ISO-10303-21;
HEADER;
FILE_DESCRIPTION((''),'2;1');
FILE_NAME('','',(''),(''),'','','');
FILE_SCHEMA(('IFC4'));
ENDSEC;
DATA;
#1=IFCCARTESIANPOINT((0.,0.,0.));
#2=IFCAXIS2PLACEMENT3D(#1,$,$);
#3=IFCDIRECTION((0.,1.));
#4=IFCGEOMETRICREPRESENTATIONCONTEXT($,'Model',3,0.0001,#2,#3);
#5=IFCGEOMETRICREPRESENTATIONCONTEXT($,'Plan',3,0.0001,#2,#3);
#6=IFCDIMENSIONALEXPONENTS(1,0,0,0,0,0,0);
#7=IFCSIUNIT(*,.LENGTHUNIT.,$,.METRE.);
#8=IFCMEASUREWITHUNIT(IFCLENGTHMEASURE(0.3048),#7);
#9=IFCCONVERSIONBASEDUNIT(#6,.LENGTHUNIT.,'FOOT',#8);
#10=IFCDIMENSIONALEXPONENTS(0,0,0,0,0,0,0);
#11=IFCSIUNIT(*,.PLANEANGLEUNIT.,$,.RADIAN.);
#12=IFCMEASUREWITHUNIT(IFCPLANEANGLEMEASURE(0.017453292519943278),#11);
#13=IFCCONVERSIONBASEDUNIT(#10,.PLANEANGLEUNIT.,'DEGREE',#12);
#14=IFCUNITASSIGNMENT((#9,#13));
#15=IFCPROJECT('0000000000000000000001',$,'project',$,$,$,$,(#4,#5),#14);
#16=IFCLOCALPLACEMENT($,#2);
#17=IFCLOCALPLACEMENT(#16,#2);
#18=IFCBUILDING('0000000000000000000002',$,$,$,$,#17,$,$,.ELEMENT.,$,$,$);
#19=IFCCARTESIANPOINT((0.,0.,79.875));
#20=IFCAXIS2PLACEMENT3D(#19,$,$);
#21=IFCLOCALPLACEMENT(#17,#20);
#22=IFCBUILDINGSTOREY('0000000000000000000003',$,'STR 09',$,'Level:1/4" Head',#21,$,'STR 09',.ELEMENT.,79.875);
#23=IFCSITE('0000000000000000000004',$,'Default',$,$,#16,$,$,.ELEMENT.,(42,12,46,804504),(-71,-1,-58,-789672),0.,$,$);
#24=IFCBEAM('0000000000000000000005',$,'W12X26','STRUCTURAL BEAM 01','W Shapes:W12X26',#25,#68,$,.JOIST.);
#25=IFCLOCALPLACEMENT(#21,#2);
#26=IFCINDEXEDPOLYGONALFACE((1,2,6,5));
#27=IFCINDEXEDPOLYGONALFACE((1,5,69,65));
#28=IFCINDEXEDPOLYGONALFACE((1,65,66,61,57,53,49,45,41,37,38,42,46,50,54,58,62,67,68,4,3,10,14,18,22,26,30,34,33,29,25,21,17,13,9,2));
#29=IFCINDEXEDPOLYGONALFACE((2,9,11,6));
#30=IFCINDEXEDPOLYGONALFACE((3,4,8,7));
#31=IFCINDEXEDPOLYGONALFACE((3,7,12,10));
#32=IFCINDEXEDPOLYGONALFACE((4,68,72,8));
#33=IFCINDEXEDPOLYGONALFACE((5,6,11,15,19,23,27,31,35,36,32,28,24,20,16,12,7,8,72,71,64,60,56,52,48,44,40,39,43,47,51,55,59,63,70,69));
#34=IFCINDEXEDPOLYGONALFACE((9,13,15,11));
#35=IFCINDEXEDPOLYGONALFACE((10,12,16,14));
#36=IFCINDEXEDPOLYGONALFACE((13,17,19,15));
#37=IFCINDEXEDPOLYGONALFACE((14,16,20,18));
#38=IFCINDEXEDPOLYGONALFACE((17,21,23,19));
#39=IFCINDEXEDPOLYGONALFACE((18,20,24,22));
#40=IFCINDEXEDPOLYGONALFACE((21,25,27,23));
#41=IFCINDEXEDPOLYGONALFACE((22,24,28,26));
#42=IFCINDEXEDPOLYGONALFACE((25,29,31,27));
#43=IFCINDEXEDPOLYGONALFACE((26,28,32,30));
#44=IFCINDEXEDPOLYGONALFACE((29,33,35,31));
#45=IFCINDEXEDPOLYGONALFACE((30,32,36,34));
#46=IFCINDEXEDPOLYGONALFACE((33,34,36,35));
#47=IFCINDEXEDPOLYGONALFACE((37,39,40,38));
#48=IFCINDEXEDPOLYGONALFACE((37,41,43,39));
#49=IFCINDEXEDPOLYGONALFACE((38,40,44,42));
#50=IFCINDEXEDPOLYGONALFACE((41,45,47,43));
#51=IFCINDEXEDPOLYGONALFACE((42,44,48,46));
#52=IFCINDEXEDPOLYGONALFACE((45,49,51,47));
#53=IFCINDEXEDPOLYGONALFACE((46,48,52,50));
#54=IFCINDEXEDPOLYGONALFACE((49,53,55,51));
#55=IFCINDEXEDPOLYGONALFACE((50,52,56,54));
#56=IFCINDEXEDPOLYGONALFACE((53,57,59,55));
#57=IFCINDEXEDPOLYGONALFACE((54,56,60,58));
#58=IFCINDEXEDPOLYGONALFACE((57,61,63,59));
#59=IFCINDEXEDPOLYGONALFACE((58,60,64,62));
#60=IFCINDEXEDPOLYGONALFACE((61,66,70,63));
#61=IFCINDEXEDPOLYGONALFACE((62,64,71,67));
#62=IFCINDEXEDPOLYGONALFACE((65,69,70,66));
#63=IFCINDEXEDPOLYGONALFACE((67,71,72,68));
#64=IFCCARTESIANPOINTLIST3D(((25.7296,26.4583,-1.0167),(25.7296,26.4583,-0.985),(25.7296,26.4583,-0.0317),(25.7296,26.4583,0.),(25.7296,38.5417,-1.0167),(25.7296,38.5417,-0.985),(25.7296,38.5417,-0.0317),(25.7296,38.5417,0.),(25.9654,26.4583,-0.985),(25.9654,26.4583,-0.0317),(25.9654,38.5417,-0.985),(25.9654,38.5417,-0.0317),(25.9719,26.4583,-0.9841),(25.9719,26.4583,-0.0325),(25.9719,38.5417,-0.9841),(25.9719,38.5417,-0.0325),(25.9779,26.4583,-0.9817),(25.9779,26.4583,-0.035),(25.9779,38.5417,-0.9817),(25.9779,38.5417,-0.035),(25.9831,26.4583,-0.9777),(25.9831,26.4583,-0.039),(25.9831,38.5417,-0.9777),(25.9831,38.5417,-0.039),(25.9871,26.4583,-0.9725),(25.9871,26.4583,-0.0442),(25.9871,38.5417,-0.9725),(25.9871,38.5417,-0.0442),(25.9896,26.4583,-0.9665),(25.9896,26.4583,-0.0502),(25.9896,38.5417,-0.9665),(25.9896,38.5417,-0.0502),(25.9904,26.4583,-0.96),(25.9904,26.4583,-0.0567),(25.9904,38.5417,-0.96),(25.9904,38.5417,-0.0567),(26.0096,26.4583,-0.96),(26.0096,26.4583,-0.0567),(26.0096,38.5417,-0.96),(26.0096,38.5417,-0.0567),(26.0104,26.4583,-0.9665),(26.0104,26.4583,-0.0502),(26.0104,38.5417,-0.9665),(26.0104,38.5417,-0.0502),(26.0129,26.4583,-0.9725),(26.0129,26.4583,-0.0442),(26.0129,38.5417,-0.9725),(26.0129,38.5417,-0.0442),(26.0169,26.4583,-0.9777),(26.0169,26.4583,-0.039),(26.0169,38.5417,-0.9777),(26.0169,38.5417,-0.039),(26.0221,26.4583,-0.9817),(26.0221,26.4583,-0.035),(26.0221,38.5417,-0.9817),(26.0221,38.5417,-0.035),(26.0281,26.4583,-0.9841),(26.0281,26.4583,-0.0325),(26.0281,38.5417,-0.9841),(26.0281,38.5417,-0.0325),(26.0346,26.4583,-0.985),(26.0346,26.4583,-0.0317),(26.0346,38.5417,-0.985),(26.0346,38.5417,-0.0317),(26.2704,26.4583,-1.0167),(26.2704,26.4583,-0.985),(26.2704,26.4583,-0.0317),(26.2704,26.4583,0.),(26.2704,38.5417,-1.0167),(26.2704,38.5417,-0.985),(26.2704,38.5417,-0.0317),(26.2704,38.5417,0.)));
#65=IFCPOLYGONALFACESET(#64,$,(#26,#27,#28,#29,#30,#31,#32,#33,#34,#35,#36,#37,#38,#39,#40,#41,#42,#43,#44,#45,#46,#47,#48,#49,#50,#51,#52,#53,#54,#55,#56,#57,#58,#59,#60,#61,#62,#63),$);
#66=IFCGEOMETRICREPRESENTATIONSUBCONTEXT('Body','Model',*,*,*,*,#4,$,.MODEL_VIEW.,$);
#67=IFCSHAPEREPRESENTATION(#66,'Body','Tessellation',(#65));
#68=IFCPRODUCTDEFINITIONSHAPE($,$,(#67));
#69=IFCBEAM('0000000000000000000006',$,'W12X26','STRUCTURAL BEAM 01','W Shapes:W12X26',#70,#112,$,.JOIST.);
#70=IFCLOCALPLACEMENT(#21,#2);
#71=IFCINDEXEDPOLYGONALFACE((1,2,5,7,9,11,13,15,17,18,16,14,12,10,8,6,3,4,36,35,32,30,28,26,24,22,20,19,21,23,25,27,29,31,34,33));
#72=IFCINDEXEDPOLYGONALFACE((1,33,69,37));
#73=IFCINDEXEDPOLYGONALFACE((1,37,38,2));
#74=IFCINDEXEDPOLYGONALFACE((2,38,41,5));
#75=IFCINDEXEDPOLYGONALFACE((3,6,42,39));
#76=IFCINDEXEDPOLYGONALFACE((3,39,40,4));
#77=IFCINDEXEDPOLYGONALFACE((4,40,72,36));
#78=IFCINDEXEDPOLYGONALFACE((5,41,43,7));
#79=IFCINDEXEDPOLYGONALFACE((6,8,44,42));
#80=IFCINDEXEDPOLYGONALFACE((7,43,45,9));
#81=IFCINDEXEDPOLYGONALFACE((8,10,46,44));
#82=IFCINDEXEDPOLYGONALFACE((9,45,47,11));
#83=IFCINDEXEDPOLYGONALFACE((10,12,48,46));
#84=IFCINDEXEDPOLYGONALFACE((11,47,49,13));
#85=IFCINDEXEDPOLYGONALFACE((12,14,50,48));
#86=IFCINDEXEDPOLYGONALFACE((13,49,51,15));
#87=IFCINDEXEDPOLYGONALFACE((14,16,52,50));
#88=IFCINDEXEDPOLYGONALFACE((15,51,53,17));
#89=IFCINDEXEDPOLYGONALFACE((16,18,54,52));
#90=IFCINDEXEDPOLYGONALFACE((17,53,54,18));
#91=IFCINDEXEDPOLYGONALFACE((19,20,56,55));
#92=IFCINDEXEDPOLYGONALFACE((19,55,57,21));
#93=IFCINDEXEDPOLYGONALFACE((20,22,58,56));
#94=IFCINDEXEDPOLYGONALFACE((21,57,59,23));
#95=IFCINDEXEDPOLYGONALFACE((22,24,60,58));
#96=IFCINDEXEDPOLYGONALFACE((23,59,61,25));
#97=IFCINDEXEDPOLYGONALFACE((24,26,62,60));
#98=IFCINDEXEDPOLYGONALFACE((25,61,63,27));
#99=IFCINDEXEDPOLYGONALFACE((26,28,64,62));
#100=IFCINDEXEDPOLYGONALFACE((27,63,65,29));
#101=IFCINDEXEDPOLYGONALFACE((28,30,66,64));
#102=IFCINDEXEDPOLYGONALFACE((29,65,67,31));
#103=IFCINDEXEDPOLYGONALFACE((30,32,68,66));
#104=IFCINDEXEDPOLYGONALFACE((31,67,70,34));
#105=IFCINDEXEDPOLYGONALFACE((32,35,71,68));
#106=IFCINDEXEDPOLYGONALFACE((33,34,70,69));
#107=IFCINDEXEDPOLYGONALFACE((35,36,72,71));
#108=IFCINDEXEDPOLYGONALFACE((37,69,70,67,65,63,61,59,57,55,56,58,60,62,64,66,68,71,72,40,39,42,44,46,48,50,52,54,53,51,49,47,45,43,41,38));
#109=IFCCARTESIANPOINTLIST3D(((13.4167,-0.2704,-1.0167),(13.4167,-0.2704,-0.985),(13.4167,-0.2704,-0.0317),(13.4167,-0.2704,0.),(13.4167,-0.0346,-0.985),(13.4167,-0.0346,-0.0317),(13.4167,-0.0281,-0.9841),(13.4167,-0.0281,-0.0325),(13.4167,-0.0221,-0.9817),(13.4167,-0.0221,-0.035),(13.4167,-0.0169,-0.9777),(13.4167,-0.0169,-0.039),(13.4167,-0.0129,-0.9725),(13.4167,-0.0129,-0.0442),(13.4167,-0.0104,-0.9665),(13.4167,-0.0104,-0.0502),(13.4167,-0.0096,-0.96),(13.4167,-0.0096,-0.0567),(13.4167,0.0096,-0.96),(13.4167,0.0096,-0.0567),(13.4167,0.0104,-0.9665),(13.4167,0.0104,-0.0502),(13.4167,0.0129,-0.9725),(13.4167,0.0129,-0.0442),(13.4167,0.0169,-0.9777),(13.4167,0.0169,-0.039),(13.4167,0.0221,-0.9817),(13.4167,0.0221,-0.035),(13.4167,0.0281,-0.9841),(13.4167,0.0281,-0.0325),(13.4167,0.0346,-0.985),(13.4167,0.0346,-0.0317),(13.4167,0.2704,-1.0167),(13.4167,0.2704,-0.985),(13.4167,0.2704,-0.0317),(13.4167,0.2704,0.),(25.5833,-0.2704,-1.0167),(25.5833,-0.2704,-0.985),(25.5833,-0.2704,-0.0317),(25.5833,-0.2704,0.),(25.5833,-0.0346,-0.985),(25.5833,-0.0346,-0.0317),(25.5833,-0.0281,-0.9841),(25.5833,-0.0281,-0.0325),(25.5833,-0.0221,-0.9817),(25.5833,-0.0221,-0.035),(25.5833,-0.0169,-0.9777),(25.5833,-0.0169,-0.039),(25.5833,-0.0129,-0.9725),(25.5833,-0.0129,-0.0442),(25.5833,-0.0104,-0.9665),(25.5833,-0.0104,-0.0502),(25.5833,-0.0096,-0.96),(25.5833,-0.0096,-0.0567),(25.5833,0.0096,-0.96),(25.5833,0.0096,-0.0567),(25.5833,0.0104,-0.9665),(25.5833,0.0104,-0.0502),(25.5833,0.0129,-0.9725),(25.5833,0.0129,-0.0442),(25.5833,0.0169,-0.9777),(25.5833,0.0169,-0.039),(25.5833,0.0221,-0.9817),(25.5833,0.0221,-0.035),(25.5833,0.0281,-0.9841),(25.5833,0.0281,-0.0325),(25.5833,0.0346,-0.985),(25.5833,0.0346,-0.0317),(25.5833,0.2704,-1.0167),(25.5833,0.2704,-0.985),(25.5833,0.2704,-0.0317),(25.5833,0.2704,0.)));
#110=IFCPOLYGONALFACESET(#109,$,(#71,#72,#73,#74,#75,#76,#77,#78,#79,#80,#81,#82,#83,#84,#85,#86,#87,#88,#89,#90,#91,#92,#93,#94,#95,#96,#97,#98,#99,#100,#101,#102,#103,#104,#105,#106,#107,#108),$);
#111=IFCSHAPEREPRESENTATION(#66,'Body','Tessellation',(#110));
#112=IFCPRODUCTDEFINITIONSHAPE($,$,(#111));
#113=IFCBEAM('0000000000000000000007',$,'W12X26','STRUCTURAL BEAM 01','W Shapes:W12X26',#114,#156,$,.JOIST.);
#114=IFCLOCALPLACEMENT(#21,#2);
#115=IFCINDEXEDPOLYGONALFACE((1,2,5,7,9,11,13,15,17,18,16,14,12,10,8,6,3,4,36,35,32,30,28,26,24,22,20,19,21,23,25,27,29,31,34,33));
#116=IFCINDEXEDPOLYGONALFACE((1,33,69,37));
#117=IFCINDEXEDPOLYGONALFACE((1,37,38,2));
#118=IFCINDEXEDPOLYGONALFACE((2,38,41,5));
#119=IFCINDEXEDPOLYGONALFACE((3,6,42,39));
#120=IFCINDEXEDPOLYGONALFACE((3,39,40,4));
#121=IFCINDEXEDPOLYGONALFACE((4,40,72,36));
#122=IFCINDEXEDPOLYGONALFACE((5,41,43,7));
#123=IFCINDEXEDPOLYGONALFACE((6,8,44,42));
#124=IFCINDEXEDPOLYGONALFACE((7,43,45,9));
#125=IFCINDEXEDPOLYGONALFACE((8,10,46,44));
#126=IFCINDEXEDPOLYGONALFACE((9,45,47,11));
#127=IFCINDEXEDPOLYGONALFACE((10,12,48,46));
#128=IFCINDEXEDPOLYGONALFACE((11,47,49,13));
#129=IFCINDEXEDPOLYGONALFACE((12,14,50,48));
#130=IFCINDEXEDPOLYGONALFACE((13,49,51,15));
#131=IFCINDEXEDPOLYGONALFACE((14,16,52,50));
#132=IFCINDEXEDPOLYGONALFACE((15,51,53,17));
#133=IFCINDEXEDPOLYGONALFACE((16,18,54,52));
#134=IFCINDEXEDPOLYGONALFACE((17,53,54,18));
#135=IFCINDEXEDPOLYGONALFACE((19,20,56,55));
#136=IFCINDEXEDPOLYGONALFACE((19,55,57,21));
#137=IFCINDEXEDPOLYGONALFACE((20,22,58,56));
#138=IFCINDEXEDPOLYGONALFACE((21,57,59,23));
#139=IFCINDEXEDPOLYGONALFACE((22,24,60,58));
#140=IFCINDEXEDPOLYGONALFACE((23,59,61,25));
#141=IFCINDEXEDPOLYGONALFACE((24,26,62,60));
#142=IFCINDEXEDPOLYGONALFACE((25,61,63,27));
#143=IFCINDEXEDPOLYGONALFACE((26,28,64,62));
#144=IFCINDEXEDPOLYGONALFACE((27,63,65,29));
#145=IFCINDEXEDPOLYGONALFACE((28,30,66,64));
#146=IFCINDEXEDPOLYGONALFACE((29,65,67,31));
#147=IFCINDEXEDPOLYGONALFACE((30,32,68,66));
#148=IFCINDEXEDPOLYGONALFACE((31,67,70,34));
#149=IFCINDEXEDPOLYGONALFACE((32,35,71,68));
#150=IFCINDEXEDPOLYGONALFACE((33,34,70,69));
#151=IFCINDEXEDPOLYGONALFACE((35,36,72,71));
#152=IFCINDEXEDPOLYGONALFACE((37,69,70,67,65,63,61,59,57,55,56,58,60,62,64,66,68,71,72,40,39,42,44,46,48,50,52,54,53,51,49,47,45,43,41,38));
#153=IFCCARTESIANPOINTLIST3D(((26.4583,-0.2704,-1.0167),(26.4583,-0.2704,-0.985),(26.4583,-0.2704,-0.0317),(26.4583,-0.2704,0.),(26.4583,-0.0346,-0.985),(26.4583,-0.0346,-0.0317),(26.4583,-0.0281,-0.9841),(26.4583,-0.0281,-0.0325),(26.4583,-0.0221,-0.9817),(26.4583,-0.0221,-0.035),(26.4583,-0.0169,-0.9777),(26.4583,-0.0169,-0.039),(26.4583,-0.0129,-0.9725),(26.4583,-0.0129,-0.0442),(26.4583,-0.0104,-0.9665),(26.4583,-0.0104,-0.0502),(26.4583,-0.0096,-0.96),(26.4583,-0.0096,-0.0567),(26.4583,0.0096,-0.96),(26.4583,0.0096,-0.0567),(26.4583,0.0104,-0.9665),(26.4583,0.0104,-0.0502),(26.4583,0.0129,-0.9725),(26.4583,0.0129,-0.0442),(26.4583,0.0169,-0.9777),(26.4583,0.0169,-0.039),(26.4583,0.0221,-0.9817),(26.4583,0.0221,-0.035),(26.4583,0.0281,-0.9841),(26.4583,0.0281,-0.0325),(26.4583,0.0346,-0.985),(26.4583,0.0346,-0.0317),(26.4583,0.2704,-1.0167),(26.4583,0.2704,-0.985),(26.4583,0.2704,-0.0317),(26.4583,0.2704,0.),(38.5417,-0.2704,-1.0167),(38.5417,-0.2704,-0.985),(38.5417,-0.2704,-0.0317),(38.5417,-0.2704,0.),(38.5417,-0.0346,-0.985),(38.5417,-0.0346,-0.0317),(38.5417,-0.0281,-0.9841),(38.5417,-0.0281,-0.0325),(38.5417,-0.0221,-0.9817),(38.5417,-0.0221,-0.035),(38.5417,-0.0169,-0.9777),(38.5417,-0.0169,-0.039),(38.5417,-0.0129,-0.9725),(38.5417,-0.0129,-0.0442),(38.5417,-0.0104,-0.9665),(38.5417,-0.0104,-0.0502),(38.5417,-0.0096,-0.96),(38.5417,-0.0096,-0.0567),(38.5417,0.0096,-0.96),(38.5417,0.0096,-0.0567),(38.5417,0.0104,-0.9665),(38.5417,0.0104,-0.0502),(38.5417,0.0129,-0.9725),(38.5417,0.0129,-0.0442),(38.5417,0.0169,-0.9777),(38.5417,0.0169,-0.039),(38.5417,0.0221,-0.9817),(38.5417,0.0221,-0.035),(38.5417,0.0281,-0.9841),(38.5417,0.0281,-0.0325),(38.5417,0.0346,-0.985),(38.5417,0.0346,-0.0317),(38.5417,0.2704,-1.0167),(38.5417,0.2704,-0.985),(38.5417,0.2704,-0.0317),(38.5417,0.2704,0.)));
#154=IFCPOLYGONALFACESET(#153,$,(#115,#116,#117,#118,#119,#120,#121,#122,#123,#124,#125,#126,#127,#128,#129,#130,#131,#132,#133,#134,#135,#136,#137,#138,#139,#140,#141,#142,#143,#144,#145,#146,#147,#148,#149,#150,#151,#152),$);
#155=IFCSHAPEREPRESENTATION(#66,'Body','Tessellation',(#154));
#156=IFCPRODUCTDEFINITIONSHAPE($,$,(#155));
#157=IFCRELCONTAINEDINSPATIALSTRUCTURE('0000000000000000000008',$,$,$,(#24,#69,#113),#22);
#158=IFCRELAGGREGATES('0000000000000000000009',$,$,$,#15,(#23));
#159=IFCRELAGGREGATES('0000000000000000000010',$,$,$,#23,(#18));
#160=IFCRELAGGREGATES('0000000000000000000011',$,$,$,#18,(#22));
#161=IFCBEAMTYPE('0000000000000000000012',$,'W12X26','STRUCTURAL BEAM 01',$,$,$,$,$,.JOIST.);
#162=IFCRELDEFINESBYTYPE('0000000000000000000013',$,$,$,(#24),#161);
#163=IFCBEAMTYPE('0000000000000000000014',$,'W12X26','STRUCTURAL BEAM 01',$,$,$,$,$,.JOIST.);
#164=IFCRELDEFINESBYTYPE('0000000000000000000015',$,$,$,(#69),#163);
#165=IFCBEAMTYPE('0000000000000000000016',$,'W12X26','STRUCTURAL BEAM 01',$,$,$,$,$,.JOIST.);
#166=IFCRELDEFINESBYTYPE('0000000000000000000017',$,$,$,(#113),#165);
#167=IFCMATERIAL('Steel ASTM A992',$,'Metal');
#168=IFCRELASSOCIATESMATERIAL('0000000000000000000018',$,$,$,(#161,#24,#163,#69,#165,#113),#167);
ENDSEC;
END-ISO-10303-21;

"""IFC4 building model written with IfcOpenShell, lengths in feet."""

from ifc_helpers import new_model, entity, si_unit, converted_unit, direction, frame, origin, place, context, subcontext, project, spatial, line, arc, indexed_curve, outline, extrude, source, transform, mapped, material, type_object, type_shapes, element, save


model = new_model("IFC4")

# Units and contexts
model_context = context("Model", 3, precision=0.0001, world=origin(), true_north=direction((0.0, 1.0)))
plan_context = context("Plan", 3, precision=0.0001, world=origin(), true_north=direction((0.0, 1.0)))
body_context = subcontext(model_context, "Body", "Model", "MODEL_VIEW")
ifc_project = project(units=[converted_unit("LENGTHUNIT", "FOOT", entity("IfcLengthMeasure", 0.3048), si_unit("LENGTHUNIT", "METRE"), dimensions=[1, 0, 0, 0, 0, 0, 0]), converted_unit("PLANEANGLEUNIT", "DEGREE", entity("IfcPlaneAngleMeasure", 0.017453292519943278), si_unit("PLANEANGLEUNIT", "RADIAN"), dimensions=[0, 0, 0, 0, 0, 0, 0])], contexts=[model_context, plan_context])

# Site, building, storey
site_placement = place(None, origin())
site = spatial("IfcSite", under=ifc_project, at=site_placement, Name="Default", CompositionType="ELEMENT", RefLatitude=(42, 12, 46, 804504), RefLongitude=(-71, -1, -58, -789672), RefElevation=0.0)
building_placement = place(site_placement, origin())
building = spatial("IfcBuilding", under=site, at=building_placement, CompositionType="ELEMENT")
storey_placement = place(building_placement, frame((0.0, 0.0, 79.875)))
storey = spatial("IfcBuildingStorey", under=building, at=storey_placement, Name="STR 09", ObjectType="Level:1/4\" Head", LongName="STR 09", CompositionType="ELEMENT", Elevation=79.875)

# Shared definitions
ifc_material = material(Name="Steel ASTM A992", Category="Metal")

# Beams
beam_type_1 = type_object("IfcBeamType", Name="W12X26", Description="STRUCTURAL BEAM 01", PredefinedType="JOIST", material=ifc_material)
shared_shape_1 = source(origin(), body_context, "Body", "SweptSolid", [
    extrude(outline(indexed_curve([(-0.2704, -0.4767), (-0.2704, -0.5083), (0.2704, -0.5083), (0.2704, -0.4767), (0.0346, -0.4767), (0.0169, -0.4693), (0.0096, -0.4517), (0.0096, 0.4517), (0.0169, 0.4693), (0.0346, 0.4767), (0.2704, 0.4767), (0.2704, 0.5083), (-0.2704, 0.5083), (-0.2704, 0.4767), (-0.0346, 0.4767), (-0.0169, 0.4693), (-0.0096, 0.4517), (-0.0096, -0.4517), (-0.0169, -0.4693), (-0.0346, -0.4767)], segments=[line(1, 2, 3, 4, 5), arc(5, 6, 7), line(7, 8), arc(8, 9, 10), line(10, 11, 12, 13, 14, 15), arc(15, 16, 17), line(17, 18), arc(18, 19, 20), line(20, 1)], self_intersect=False)), frame((-6.165, 0.0, 0.0), z_axis=(-1.0, 0.0, 0.0), x_axis=(0.0, -1.0, 0.0)), (0.0, 0.0, -1.0), 12.0833),
])
type_shapes(beam_type_1, [shared_shape_1])
for number, where, z_axis, x_axis, name in (
    (1, (26.0, 32.6234, -0.5083), (0.0, 0.0, 1.0), (0.0, 1.0, 0.0), "W12X26"),
):
    element("IfcBeam", number, at=place(storey_placement, frame(where, z_axis=z_axis, x_axis=x_axis)), inside=storey, type_object=beam_type_1, material=ifc_material, Name=name, Description="STRUCTURAL BEAM 01", ObjectType="W Shapes:W12X26", PredefinedType="JOIST", context=body_context, shape_type="MappedRepresentation", body=[
        mapped(shared_shape_1, transform((0.0, 0.0, 0.0), scale=1.0)),
    ])
beam_type_2 = type_object("IfcBeamType", Name="W12X26", Description="STRUCTURAL BEAM 01", PredefinedType="JOIST", material=ifc_material)
shared_shape_2 = source(origin(), body_context, "Body", "SweptSolid", [
    extrude(outline(indexed_curve([(-0.2704, -0.4767), (-0.2704, -0.5083), (0.2704, -0.5083), (0.2704, -0.4767), (0.0346, -0.4767), (0.0169, -0.4693), (0.0096, -0.4517), (0.0096, 0.4517), (0.0169, 0.4693), (0.0346, 0.4767), (0.2704, 0.4767), (0.2704, 0.5083), (-0.2704, 0.5083), (-0.2704, 0.4767), (-0.0346, 0.4767), (-0.0169, 0.4693), (-0.0096, 0.4517), (-0.0096, -0.4517), (-0.0169, -0.4693), (-0.0346, -0.4767)], segments=[line(1, 2, 3, 4, 5), arc(5, 6, 7), line(7, 8), arc(8, 9, 10), line(10, 11, 12, 13, 14, 15), arc(15, 16, 17), line(17, 18), arc(18, 19, 20), line(20, 1)], self_intersect=False)), frame((-6.2917, 0.0, 0.0), z_axis=(-1.0, 0.0, 0.0), x_axis=(0.0, -1.0, 0.0)), (0.0, 0.0, -1.0), 12.1667),
])
type_shapes(beam_type_2, [shared_shape_2])
beam_1_placement = place(storey_placement, frame((19.7083, 0.0, -0.5083)))
element("IfcBeam", 2, at=beam_1_placement, inside=storey, type_object=beam_type_2, material=ifc_material, Name="W12X26", Description="STRUCTURAL BEAM 01", ObjectType="W Shapes:W12X26", PredefinedType="JOIST", context=body_context, shape_type="MappedRepresentation", body=[
    mapped(shared_shape_2, transform((0.0, 0.0, 0.0), scale=1.0)),
])
beam_type_3 = type_object("IfcBeamType", Name="W12X26", Description="STRUCTURAL BEAM 01", PredefinedType="JOIST", material=ifc_material)
shared_shape_3 = source(origin(), body_context, "Body", "SweptSolid", [
    extrude(outline(indexed_curve([(-0.2704, -0.4767), (-0.2704, -0.5083), (0.2704, -0.5083), (0.2704, -0.4767), (0.0346, -0.4767), (0.0169, -0.4693), (0.0096, -0.4517), (0.0096, 0.4517), (0.0169, 0.4693), (0.0346, 0.4767), (0.2704, 0.4767), (0.2704, 0.5083), (-0.2704, 0.5083), (-0.2704, 0.4767), (-0.0346, 0.4767), (-0.0169, 0.4693), (-0.0096, 0.4517), (-0.0096, -0.4517), (-0.0169, -0.4693), (-0.0346, -0.4767)], segments=[line(1, 2, 3, 4, 5), arc(5, 6, 7), line(7, 8), arc(8, 9, 10), line(10, 11, 12, 13, 14, 15), arc(15, 16, 17), line(17, 18), arc(18, 19, 20), line(20, 1)], self_intersect=False)), frame((-6.0417, 0.0, 0.0), z_axis=(-1.0, 0.0, 0.0), x_axis=(0.0, -1.0, 0.0)), (0.0, 0.0, -1.0), 12.0833),
])
type_shapes(beam_type_3, [shared_shape_3])
beam_2_placement = place(storey_placement, frame((32.5, 0.0, -0.5083)))
element("IfcBeam", 3, at=beam_2_placement, inside=storey, type_object=beam_type_3, material=ifc_material, Name="W12X26", Description="STRUCTURAL BEAM 01", ObjectType="W Shapes:W12X26", PredefinedType="JOIST", context=body_context, shape_type="MappedRepresentation", body=[
    mapped(shared_shape_3, transform((0.0, 0.0, 0.0), scale=1.0)),
])

save(model, "model.ifc")
